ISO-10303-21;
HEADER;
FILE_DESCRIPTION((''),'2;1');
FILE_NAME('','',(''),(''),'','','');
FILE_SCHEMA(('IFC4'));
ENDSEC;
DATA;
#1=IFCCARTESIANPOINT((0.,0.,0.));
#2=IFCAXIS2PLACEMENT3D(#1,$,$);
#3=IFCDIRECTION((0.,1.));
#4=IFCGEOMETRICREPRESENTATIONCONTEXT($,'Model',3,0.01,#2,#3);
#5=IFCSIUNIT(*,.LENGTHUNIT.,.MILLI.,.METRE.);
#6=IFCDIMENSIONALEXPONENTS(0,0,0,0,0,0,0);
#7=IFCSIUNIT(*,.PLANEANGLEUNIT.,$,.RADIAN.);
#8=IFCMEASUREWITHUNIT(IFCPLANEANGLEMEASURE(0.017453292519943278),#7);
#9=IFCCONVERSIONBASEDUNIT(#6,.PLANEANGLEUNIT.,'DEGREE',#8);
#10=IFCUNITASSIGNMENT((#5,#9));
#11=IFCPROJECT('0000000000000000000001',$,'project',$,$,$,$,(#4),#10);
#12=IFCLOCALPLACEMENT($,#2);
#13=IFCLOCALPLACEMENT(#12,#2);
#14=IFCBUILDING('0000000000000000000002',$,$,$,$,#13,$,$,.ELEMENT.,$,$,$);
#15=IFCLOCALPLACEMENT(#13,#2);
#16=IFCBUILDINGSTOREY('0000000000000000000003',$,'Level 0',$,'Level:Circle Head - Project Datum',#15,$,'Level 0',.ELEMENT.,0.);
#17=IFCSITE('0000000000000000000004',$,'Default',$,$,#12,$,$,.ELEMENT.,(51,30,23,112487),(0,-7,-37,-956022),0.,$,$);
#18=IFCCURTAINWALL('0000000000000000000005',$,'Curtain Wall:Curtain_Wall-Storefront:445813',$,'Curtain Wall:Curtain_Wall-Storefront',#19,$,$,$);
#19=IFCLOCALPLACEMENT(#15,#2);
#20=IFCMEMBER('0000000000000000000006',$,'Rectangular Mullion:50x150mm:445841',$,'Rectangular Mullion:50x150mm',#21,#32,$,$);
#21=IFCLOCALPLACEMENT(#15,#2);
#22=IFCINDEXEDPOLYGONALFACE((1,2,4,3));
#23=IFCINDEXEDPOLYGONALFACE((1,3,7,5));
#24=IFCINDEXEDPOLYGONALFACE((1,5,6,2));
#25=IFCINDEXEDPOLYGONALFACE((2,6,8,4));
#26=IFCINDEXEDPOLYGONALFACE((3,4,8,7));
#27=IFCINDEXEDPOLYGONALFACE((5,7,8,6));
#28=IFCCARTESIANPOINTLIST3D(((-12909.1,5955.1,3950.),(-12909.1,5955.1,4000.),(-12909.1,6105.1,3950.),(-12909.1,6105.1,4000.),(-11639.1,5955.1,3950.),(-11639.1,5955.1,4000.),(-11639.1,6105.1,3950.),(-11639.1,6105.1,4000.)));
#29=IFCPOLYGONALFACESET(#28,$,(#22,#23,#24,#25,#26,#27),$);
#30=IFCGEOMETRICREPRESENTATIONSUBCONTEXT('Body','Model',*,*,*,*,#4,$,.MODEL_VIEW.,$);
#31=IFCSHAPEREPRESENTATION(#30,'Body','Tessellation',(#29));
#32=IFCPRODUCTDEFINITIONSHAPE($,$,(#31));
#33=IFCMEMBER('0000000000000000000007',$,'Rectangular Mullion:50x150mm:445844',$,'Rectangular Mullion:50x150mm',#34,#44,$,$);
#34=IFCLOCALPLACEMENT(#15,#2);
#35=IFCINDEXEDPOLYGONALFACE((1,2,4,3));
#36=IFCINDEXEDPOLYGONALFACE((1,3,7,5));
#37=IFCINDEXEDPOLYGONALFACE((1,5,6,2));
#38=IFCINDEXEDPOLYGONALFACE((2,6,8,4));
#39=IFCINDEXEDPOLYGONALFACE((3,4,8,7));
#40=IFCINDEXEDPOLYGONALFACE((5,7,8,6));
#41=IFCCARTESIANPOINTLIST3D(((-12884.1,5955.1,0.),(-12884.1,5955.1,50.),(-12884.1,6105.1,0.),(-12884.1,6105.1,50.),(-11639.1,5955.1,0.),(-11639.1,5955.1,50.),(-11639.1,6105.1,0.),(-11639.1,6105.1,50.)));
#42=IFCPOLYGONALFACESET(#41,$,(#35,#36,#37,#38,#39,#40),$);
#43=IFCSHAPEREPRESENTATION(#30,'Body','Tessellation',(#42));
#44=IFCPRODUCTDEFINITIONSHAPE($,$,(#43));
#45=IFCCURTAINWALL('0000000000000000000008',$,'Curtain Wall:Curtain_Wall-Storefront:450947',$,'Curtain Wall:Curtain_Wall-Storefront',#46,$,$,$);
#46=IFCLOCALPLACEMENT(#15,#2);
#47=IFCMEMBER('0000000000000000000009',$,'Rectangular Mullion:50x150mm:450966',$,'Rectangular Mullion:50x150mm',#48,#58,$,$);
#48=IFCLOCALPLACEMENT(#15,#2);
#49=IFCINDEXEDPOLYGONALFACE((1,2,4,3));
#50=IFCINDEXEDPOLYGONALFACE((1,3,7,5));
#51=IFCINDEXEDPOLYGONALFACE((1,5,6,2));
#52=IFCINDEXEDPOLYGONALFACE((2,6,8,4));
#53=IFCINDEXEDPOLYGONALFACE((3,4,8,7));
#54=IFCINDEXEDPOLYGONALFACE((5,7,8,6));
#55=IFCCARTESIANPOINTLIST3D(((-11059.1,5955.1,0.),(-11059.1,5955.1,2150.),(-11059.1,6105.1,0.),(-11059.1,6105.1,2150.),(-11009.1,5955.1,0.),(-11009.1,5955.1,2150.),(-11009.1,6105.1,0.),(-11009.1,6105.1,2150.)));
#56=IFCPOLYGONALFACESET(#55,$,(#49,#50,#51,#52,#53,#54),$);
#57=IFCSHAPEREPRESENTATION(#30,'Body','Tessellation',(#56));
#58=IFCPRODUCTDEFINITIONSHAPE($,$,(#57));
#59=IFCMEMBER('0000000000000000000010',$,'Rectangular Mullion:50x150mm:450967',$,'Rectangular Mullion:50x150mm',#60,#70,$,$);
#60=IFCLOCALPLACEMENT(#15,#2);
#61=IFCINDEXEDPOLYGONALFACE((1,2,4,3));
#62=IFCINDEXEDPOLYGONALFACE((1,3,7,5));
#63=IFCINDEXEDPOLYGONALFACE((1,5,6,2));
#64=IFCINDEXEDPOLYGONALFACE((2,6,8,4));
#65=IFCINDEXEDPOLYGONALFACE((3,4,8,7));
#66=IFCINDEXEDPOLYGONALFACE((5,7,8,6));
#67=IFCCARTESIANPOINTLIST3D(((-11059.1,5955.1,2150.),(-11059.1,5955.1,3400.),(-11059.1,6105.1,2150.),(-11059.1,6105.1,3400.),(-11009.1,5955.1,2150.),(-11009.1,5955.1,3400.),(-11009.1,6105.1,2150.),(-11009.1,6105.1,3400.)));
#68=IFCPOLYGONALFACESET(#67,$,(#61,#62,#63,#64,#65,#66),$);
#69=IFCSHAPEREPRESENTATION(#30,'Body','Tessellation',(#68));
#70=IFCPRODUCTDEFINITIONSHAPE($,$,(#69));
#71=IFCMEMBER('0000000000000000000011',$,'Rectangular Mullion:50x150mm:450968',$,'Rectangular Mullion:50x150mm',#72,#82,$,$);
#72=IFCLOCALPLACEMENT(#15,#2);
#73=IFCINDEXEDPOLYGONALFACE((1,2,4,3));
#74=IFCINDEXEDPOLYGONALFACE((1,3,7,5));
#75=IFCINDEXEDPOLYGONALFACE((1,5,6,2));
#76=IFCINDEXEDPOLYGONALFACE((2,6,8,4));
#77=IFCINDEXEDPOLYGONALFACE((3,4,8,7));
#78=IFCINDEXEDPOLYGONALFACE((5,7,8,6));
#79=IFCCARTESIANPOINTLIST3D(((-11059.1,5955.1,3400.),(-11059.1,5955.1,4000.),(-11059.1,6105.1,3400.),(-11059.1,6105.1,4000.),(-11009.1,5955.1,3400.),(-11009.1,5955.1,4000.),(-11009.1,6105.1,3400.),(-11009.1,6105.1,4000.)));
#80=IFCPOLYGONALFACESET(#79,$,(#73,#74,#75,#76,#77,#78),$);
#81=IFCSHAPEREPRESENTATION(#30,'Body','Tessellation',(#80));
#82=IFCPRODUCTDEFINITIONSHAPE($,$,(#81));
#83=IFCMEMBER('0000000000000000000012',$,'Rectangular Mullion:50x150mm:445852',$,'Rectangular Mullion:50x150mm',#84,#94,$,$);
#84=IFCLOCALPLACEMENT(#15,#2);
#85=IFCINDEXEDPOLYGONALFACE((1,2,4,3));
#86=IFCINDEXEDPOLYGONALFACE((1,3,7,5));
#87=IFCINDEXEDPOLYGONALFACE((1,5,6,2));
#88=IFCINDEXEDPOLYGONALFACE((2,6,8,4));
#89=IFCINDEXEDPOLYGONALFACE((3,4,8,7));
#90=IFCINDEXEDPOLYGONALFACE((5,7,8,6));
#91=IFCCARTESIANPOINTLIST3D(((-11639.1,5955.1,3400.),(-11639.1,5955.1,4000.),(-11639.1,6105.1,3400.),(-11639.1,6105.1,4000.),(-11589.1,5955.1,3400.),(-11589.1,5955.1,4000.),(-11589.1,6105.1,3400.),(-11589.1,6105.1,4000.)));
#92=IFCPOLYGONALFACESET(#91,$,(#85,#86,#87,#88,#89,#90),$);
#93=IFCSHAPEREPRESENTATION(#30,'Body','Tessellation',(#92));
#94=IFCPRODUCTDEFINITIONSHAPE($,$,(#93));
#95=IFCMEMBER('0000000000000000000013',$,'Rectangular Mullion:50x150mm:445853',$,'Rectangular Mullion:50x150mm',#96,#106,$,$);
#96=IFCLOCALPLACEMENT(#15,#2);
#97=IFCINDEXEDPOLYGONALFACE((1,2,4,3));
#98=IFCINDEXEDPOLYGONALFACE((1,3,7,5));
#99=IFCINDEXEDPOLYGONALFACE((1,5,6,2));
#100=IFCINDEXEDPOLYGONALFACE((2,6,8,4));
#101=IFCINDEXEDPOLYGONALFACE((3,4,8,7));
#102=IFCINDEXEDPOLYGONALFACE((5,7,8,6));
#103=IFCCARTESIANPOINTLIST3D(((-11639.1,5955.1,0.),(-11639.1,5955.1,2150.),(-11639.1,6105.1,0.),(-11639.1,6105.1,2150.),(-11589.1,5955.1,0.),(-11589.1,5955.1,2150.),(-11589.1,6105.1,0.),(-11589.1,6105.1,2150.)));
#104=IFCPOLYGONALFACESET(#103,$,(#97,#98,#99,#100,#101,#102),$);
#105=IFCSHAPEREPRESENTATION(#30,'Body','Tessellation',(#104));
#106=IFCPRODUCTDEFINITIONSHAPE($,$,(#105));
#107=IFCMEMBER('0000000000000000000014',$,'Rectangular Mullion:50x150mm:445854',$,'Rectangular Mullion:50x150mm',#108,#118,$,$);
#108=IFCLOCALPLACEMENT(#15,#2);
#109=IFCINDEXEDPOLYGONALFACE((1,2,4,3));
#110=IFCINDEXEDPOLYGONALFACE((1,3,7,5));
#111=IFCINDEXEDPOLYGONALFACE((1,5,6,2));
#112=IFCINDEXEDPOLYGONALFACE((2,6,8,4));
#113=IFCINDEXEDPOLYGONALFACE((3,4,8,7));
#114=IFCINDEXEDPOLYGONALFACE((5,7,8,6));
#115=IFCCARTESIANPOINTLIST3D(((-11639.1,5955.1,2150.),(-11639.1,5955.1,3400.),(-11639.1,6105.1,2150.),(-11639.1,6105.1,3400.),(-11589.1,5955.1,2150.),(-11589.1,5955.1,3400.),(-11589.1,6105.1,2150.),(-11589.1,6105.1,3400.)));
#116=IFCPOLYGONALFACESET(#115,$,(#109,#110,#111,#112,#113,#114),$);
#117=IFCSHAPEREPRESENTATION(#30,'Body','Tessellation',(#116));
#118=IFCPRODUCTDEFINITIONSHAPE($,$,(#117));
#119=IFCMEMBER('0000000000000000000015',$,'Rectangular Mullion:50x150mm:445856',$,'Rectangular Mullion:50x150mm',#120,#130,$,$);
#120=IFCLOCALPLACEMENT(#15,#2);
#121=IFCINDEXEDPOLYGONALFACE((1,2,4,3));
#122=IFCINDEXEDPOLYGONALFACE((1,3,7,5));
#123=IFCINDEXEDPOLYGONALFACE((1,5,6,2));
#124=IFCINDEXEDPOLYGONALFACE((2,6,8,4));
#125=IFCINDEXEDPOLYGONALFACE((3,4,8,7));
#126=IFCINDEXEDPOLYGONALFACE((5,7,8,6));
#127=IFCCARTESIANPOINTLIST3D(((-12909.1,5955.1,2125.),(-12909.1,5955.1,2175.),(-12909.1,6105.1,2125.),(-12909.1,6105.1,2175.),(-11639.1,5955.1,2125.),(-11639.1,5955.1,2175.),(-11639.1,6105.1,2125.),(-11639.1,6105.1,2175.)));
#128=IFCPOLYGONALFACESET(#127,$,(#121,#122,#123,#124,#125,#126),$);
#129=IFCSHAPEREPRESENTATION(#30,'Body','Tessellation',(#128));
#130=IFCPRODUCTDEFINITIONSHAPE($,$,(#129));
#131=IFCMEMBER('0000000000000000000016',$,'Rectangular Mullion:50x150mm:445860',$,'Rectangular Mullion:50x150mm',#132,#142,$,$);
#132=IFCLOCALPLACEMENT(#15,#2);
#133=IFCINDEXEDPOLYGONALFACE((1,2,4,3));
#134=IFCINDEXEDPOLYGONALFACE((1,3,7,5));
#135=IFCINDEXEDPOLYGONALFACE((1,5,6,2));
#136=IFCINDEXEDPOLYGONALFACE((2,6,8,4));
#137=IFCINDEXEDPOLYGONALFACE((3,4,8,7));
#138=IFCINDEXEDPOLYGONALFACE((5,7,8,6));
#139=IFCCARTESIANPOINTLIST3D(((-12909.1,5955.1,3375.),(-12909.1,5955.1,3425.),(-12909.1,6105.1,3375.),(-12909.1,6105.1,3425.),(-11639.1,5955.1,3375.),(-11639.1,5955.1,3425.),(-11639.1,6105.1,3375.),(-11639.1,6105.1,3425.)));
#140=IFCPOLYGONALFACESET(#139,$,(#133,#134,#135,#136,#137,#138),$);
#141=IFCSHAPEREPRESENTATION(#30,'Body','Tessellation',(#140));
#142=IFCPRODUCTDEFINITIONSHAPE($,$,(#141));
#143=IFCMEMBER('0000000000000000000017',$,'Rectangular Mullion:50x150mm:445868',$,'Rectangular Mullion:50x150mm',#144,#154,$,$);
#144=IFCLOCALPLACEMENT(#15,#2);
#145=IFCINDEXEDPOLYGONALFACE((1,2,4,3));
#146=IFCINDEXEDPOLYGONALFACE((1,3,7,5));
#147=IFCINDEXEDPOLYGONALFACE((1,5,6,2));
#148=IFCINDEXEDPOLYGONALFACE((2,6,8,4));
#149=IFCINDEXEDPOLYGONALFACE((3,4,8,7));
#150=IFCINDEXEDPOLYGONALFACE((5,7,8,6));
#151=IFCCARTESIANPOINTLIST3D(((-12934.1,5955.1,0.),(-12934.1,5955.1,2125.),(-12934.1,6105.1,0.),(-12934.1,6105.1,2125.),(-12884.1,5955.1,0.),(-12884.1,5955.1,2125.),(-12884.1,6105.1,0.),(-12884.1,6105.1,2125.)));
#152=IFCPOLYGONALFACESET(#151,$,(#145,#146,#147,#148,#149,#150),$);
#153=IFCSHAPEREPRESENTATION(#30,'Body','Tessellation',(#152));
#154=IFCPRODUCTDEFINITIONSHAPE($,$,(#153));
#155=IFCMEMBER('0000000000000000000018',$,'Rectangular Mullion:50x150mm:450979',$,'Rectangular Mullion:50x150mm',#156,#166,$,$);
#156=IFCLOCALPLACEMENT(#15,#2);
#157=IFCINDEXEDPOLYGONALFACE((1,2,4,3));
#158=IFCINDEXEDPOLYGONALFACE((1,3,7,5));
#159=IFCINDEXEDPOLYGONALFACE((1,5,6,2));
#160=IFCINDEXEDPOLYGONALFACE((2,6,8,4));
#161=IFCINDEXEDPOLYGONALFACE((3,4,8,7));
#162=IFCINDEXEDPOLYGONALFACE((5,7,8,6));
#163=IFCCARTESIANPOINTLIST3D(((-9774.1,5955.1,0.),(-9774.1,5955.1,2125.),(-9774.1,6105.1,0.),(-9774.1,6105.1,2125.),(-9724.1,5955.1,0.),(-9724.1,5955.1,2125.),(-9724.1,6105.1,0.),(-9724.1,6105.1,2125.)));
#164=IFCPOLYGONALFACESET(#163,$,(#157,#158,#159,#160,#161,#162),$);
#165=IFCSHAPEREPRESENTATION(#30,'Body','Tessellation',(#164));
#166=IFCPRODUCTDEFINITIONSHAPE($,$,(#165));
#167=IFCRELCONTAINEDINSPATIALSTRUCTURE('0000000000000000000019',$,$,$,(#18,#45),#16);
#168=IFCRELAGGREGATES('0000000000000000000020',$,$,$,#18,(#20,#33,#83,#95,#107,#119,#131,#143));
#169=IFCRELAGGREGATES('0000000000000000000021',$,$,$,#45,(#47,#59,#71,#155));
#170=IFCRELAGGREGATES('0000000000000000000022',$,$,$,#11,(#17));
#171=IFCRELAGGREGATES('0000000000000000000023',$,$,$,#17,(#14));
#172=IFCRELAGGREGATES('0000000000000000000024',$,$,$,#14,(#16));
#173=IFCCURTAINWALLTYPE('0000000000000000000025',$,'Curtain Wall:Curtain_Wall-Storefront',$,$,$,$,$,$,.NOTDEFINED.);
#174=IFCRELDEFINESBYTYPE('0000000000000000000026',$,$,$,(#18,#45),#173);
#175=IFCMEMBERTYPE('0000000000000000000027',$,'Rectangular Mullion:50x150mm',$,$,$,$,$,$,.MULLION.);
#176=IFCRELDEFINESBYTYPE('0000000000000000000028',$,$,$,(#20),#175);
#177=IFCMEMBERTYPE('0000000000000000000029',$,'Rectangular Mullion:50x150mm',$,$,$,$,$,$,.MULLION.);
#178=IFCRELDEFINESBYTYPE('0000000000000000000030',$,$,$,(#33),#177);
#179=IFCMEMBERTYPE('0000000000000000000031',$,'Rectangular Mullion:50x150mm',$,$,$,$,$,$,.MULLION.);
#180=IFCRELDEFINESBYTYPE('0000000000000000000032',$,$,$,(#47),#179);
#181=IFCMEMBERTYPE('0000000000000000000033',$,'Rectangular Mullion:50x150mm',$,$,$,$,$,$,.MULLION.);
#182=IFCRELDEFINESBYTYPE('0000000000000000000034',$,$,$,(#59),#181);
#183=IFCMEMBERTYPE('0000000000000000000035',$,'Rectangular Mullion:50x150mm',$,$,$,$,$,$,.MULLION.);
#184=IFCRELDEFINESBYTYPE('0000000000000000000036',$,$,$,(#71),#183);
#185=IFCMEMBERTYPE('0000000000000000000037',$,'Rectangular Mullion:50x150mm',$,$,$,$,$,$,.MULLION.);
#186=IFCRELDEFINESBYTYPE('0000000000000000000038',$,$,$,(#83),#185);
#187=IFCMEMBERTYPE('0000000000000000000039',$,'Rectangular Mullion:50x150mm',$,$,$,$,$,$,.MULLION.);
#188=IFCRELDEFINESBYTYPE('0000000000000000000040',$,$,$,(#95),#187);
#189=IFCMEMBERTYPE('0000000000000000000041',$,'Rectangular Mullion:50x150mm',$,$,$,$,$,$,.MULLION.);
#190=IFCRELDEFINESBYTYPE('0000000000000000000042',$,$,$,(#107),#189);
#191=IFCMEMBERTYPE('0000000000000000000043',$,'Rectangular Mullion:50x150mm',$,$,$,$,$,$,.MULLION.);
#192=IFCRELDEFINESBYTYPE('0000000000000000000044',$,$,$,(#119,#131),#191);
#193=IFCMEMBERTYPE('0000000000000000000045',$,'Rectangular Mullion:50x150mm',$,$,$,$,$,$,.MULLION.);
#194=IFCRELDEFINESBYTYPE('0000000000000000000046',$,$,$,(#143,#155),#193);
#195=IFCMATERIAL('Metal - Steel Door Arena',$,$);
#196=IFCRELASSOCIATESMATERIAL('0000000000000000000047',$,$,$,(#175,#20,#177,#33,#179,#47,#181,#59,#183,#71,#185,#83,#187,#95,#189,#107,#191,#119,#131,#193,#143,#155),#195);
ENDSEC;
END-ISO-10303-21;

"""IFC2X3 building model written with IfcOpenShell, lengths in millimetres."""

from ifc_helpers import new_model, entity, si_unit, converted_unit, direction, frame, origin, origin_2d_with_axis, place, context, subcontext, project, spatial, rectangle, extrude, source, transform, mapped, material, type_object, type_shapes, element, aggregate, save


model = new_model("IFC2X3")

# Units and contexts
model_context = context("Model", 3, precision=0.01, world=origin(), true_north=direction((0.0, 1.0)))
body_context = subcontext(model_context, "Body", "Model", "MODEL_VIEW")
ifc_project = project(units=[si_unit("LENGTHUNIT", "METRE", prefix="MILLI"), converted_unit("PLANEANGLEUNIT", "DEGREE", entity("IfcPlaneAngleMeasure", 0.017453292519943278), si_unit("PLANEANGLEUNIT", "RADIAN"), dimensions=[0, 0, 0, 0, 0, 0, 0])], contexts=[model_context])

# Site, building, storey
site_placement = place(None, origin())
site = spatial("IfcSite", under=ifc_project, at=site_placement, Name="Default", CompositionType="ELEMENT", RefLatitude=(51, 30, 23, 112487), RefLongitude=(0, -7, -37, -956022), RefElevation=0.0)
building_placement = place(site_placement, origin())
building = spatial("IfcBuilding", under=site, at=building_placement, CompositionType="ELEMENT")
storey_placement = place(building_placement, origin())
storey = spatial("IfcBuildingStorey", under=building, at=storey_placement, Name="Level 0", ObjectType="Level:Circle Head - Project Datum", LongName="Level 0", CompositionType="ELEMENT", Elevation=0.0)

# Curtain walls, members
curtain_wall_type = type_object("IfcCurtainWallType", Name="Curtain Wall:Curtain_Wall-Storefront", PredefinedType="NOTDEFINED")
curtain_wall_1_placement = place(storey_placement, origin())
curtain_wall_1 = element("IfcCurtainWall", 1, at=curtain_wall_1_placement, inside=storey, type_object=curtain_wall_type, Name="Curtain Wall:Curtain_Wall-Storefront:445813", ObjectType="Curtain Wall:Curtain_Wall-Storefront")
ifc_material_1 = material(Name="Metal - Steel Door Arena")
member_type_1 = type_object("IfcMemberType", Name="Rectangular Mullion:50x150mm", PredefinedType="MULLION", material=ifc_material_1)
shared_shape_1 = source(origin(), body_context, "Body", "SweptSolid", [
    extrude(rectangle(XDim=50.0, YDim=150.0, at=origin_2d_with_axis()), frame((-25.0, 0.0, -1270.0), z_axis=(0.0, 0.0, 1.0), x_axis=(-1.0, 0.0, 0.0)), (0.0, 0.0, 1.0), 1270.0),
])
type_shapes(member_type_1, [shared_shape_1])
member_1_placement = place(curtain_wall_1_placement, frame((-12909.1, 6030.1, 4000.0), z_axis=(-1.0, 0.0, 0.0), x_axis=(0.0, 0.0, 1.0)))
member_1 = element("IfcMember", 2, at=member_1_placement, type_object=member_type_1, material=ifc_material_1, Name="Rectangular Mullion:50x150mm:445841", ObjectType="Rectangular Mullion:50x150mm", context=body_context, shape_type="MappedRepresentation", body=[
    mapped(shared_shape_1, transform((0.0, 0.0, 0.0), scale=1.0)),
])
member_type_2 = type_object("IfcMemberType", Name="Rectangular Mullion:50x150mm", PredefinedType="MULLION", material=ifc_material_1)
shared_shape_2 = source(origin(), body_context, "Body", "SweptSolid", [
    extrude(rectangle(XDim=50.0, YDim=150.0, at=origin_2d_with_axis()), frame((-25.0, 0.0, -1245.0), z_axis=(0.0, 0.0, 1.0), x_axis=(-1.0, 0.0, 0.0)), (0.0, 0.0, 1.0), 1245.0),
])
type_shapes(member_type_2, [shared_shape_2])
member_2_placement = place(curtain_wall_1_placement, frame((-11639.1, 6030.1, 0.0), z_axis=(1.0, 0.0, 0.0), x_axis=(0.0, 0.0, -1.0)))
member_2 = element("IfcMember", 3, at=member_2_placement, type_object=member_type_2, material=ifc_material_1, Name="Rectangular Mullion:50x150mm:445844", ObjectType="Rectangular Mullion:50x150mm", context=body_context, shape_type="MappedRepresentation", body=[
    mapped(shared_shape_2, transform((0.0, 0.0, 0.0), scale=1.0)),
])
curtain_wall_2_placement = place(storey_placement, origin())
curtain_wall_2 = element("IfcCurtainWall", 4, at=curtain_wall_2_placement, inside=storey, type_object=curtain_wall_type, Name="Curtain Wall:Curtain_Wall-Storefront:450947", ObjectType="Curtain Wall:Curtain_Wall-Storefront")
member_type_3 = type_object("IfcMemberType", Name="Rectangular Mullion:50x150mm", PredefinedType="MULLION", material=ifc_material_1)
shared_shape_3 = source(origin(), body_context, "Body", "SweptSolid", [
    extrude(rectangle(XDim=50.0, YDim=150.0, at=origin_2d_with_axis()), frame((-25.0, 0.0, -2150.0), z_axis=(0.0, 0.0, 1.0), x_axis=(-1.0, 0.0, 0.0)), (0.0, 0.0, 1.0), 2150.0),
])
type_shapes(member_type_3, [shared_shape_3])
member_3_placement = place(curtain_wall_2_placement, frame((-11059.1, 6030.1, 0.0), z_axis=(0.0, 0.0, -1.0), x_axis=(-1.0, 0.0, 0.0)))
member_3 = element("IfcMember", 5, at=member_3_placement, type_object=member_type_3, material=ifc_material_1, Name="Rectangular Mullion:50x150mm:450966", ObjectType="Rectangular Mullion:50x150mm", context=body_context, shape_type="MappedRepresentation", body=[
    mapped(shared_shape_3, transform((0.0, 0.0, 0.0), scale=1.0)),
])
member_type_4 = type_object("IfcMemberType", Name="Rectangular Mullion:50x150mm", PredefinedType="MULLION", material=ifc_material_1)
shared_shape_4 = source(origin(), body_context, "Body", "SweptSolid", [
    extrude(rectangle(XDim=50.0, YDim=150.0, at=origin_2d_with_axis()), frame((-25.0, 0.0, -1250.0), z_axis=(0.0, 0.0, 1.0), x_axis=(-1.0, 0.0, 0.0)), (0.0, 0.0, 1.0), 1250.0),
])
type_shapes(member_type_4, [shared_shape_4])
member_4_placement = place(curtain_wall_2_placement, frame((-11059.1, 6030.1, 2150.0), z_axis=(0.0, 0.0, -1.0), x_axis=(-1.0, 0.0, 0.0)))
member_4 = element("IfcMember", 6, at=member_4_placement, type_object=member_type_4, material=ifc_material_1, Name="Rectangular Mullion:50x150mm:450967", ObjectType="Rectangular Mullion:50x150mm", context=body_context, shape_type="MappedRepresentation", body=[
    mapped(shared_shape_4, transform((0.0, 0.0, 0.0), scale=1.0)),
])
member_type_5 = type_object("IfcMemberType", Name="Rectangular Mullion:50x150mm", PredefinedType="MULLION", material=ifc_material_1)
shared_shape_5 = source(origin(), body_context, "Body", "SweptSolid", [
    extrude(rectangle(XDim=50.0, YDim=150.0, at=origin_2d_with_axis()), frame((-25.0, 0.0, -600.0), z_axis=(0.0, 0.0, 1.0), x_axis=(-1.0, 0.0, 0.0)), (0.0, 0.0, 1.0), 600.0),
])
type_shapes(member_type_5, [shared_shape_5])
member_5_placement = place(curtain_wall_2_placement, frame((-11059.1, 6030.1, 3400.0), z_axis=(0.0, 0.0, -1.0), x_axis=(-1.0, 0.0, 0.0)))
member_5 = element("IfcMember", 7, at=member_5_placement, type_object=member_type_5, material=ifc_material_1, Name="Rectangular Mullion:50x150mm:450968", ObjectType="Rectangular Mullion:50x150mm", context=body_context, shape_type="MappedRepresentation", body=[
    mapped(shared_shape_5, transform((0.0, 0.0, 0.0), scale=1.0)),
])

# Members
member_type_6 = type_object("IfcMemberType", Name="Rectangular Mullion:50x150mm", PredefinedType="MULLION", material=ifc_material_1)
shared_shape_6 = source(origin(), body_context, "Body", "SweptSolid", [
    extrude(rectangle(XDim=50.0, YDim=150.0, at=origin_2d_with_axis()), frame((-25.0, 0.0, -600.0), z_axis=(0.0, 0.0, 1.0), x_axis=(-1.0, 0.0, 0.0)), (0.0, 0.0, 1.0), 600.0),
])
type_shapes(member_type_6, [shared_shape_6])
member_6_placement = place(curtain_wall_1_placement, frame((-11589.1, 6030.1, 4000.0)))
member_6 = element("IfcMember", 8, at=member_6_placement, type_object=member_type_6, material=ifc_material_1, Name="Rectangular Mullion:50x150mm:445852", ObjectType="Rectangular Mullion:50x150mm", context=body_context, shape_type="MappedRepresentation", body=[
    mapped(shared_shape_6, transform((0.0, 0.0, 0.0), scale=1.0)),
])
member_type_7 = type_object("IfcMemberType", Name="Rectangular Mullion:50x150mm", PredefinedType="MULLION", material=ifc_material_1)
shared_shape_7 = source(origin(), body_context, "Body", "SweptSolid", [
    extrude(rectangle(XDim=50.0, YDim=150.0, at=origin_2d_with_axis()), frame((-25.0, 0.0, -2150.0), z_axis=(0.0, 0.0, 1.0), x_axis=(-1.0, 0.0, 0.0)), (0.0, 0.0, 1.0), 2150.0),
])
type_shapes(member_type_7, [shared_shape_7])
member_7_placement = place(curtain_wall_1_placement, frame((-11589.1, 6030.1, 2150.0)))
member_7 = element("IfcMember", 9, at=member_7_placement, type_object=member_type_7, material=ifc_material_1, Name="Rectangular Mullion:50x150mm:445853", ObjectType="Rectangular Mullion:50x150mm", context=body_context, shape_type="MappedRepresentation", body=[
    mapped(shared_shape_7, transform((0.0, 0.0, 0.0), scale=1.0)),
])
member_type_8 = type_object("IfcMemberType", Name="Rectangular Mullion:50x150mm", PredefinedType="MULLION", material=ifc_material_1)
shared_shape_8 = source(origin(), body_context, "Body", "SweptSolid", [
    extrude(rectangle(XDim=50.0, YDim=150.0, at=origin_2d_with_axis()), frame((-25.0, 0.0, -1250.0), z_axis=(0.0, 0.0, 1.0), x_axis=(-1.0, 0.0, 0.0)), (0.0, 0.0, 1.0), 1250.0),
])
type_shapes(member_type_8, [shared_shape_8])
member_8_placement = place(curtain_wall_1_placement, frame((-11589.1, 6030.1, 3400.0)))
member_8 = element("IfcMember", 10, at=member_8_placement, type_object=member_type_8, material=ifc_material_1, Name="Rectangular Mullion:50x150mm:445854", ObjectType="Rectangular Mullion:50x150mm", context=body_context, shape_type="MappedRepresentation", body=[
    mapped(shared_shape_8, transform((0.0, 0.0, 0.0), scale=1.0)),
])
member_type_9 = type_object("IfcMemberType", Name="Rectangular Mullion:50x150mm", PredefinedType="MULLION", material=ifc_material_1)
shared_shape_9 = source(origin(), body_context, "Body", "SweptSolid", [
    extrude(rectangle(XDim=50.0, YDim=150.0, at=origin_2d_with_axis()), frame((0.0, 0.0, -1270.0), z_axis=(0.0, 0.0, 1.0), x_axis=(-1.0, 0.0, 0.0)), (0.0, 0.0, 1.0), 1270.0),
])
type_shapes(member_type_9, [shared_shape_9])
member_9_placement = place(curtain_wall_1_placement, frame((-12909.1, 6030.1, 2150.0), z_axis=(-1.0, 0.0, 0.0), x_axis=(0.0, 0.0, 1.0)))
member_9 = element("IfcMember", 11, at=member_9_placement, type_object=member_type_9, material=ifc_material_1, Name="Rectangular Mullion:50x150mm:445856", ObjectType="Rectangular Mullion:50x150mm", context=body_context, shape_type="MappedRepresentation", body=[
    mapped(shared_shape_9, transform((0.0, 0.0, 0.0), scale=1.0)),
])
member_10_placement = place(curtain_wall_1_placement, frame((-12909.1, 6030.1, 3400.0), z_axis=(-1.0, 0.0, 0.0), x_axis=(0.0, 0.0, 1.0)))
member_10 = element("IfcMember", 12, at=member_10_placement, type_object=member_type_9, material=ifc_material_1, Name="Rectangular Mullion:50x150mm:445860", ObjectType="Rectangular Mullion:50x150mm", context=body_context, shape_type="MappedRepresentation", body=[
    mapped(shared_shape_9, transform((0.0, 0.0, 0.0), scale=1.0)),
])
member_type_10 = type_object("IfcMemberType", Name="Rectangular Mullion:50x150mm", PredefinedType="MULLION", material=ifc_material_1)
shared_shape_10 = source(origin(), body_context, "Body", "SweptSolid", [
    extrude(rectangle(XDim=50.0, YDim=150.0, at=origin_2d_with_axis()), frame((0.0, 0.0, -2125.0), z_axis=(0.0, 0.0, 1.0), x_axis=(-1.0, 0.0, 0.0)), (0.0, 0.0, 1.0), 2125.0),
])
type_shapes(member_type_10, [shared_shape_10])
member_11_placement = place(curtain_wall_1_placement, frame((-12909.1, 6030.1, 0.0), z_axis=(0.0, 0.0, -1.0), x_axis=(-1.0, 0.0, 0.0)))
member_11 = element("IfcMember", 13, at=member_11_placement, type_object=member_type_10, material=ifc_material_1, Name="Rectangular Mullion:50x150mm:445868", ObjectType="Rectangular Mullion:50x150mm", context=body_context, shape_type="MappedRepresentation", body=[
    mapped(shared_shape_10, transform((0.0, 0.0, 0.0), scale=1.0)),
])
member_12_placement = place(curtain_wall_2_placement, frame((-9749.1, 6030.1, 0.0), z_axis=(0.0, 0.0, -1.0), x_axis=(-1.0, 0.0, 0.0)))
member_12 = element("IfcMember", 14, at=member_12_placement, type_object=member_type_10, material=ifc_material_1, Name="Rectangular Mullion:50x150mm:450979", ObjectType="Rectangular Mullion:50x150mm", context=body_context, shape_type="MappedRepresentation", body=[
    mapped(shared_shape_10, transform((0.0, 0.0, 0.0), scale=1.0)),
])

aggregate(curtain_wall_1, [member_1, member_2, member_6, member_7, member_8, member_9, member_10, member_11])
aggregate(curtain_wall_2, [member_3, member_4, member_5, member_12])

save(model, "model.ifc")
